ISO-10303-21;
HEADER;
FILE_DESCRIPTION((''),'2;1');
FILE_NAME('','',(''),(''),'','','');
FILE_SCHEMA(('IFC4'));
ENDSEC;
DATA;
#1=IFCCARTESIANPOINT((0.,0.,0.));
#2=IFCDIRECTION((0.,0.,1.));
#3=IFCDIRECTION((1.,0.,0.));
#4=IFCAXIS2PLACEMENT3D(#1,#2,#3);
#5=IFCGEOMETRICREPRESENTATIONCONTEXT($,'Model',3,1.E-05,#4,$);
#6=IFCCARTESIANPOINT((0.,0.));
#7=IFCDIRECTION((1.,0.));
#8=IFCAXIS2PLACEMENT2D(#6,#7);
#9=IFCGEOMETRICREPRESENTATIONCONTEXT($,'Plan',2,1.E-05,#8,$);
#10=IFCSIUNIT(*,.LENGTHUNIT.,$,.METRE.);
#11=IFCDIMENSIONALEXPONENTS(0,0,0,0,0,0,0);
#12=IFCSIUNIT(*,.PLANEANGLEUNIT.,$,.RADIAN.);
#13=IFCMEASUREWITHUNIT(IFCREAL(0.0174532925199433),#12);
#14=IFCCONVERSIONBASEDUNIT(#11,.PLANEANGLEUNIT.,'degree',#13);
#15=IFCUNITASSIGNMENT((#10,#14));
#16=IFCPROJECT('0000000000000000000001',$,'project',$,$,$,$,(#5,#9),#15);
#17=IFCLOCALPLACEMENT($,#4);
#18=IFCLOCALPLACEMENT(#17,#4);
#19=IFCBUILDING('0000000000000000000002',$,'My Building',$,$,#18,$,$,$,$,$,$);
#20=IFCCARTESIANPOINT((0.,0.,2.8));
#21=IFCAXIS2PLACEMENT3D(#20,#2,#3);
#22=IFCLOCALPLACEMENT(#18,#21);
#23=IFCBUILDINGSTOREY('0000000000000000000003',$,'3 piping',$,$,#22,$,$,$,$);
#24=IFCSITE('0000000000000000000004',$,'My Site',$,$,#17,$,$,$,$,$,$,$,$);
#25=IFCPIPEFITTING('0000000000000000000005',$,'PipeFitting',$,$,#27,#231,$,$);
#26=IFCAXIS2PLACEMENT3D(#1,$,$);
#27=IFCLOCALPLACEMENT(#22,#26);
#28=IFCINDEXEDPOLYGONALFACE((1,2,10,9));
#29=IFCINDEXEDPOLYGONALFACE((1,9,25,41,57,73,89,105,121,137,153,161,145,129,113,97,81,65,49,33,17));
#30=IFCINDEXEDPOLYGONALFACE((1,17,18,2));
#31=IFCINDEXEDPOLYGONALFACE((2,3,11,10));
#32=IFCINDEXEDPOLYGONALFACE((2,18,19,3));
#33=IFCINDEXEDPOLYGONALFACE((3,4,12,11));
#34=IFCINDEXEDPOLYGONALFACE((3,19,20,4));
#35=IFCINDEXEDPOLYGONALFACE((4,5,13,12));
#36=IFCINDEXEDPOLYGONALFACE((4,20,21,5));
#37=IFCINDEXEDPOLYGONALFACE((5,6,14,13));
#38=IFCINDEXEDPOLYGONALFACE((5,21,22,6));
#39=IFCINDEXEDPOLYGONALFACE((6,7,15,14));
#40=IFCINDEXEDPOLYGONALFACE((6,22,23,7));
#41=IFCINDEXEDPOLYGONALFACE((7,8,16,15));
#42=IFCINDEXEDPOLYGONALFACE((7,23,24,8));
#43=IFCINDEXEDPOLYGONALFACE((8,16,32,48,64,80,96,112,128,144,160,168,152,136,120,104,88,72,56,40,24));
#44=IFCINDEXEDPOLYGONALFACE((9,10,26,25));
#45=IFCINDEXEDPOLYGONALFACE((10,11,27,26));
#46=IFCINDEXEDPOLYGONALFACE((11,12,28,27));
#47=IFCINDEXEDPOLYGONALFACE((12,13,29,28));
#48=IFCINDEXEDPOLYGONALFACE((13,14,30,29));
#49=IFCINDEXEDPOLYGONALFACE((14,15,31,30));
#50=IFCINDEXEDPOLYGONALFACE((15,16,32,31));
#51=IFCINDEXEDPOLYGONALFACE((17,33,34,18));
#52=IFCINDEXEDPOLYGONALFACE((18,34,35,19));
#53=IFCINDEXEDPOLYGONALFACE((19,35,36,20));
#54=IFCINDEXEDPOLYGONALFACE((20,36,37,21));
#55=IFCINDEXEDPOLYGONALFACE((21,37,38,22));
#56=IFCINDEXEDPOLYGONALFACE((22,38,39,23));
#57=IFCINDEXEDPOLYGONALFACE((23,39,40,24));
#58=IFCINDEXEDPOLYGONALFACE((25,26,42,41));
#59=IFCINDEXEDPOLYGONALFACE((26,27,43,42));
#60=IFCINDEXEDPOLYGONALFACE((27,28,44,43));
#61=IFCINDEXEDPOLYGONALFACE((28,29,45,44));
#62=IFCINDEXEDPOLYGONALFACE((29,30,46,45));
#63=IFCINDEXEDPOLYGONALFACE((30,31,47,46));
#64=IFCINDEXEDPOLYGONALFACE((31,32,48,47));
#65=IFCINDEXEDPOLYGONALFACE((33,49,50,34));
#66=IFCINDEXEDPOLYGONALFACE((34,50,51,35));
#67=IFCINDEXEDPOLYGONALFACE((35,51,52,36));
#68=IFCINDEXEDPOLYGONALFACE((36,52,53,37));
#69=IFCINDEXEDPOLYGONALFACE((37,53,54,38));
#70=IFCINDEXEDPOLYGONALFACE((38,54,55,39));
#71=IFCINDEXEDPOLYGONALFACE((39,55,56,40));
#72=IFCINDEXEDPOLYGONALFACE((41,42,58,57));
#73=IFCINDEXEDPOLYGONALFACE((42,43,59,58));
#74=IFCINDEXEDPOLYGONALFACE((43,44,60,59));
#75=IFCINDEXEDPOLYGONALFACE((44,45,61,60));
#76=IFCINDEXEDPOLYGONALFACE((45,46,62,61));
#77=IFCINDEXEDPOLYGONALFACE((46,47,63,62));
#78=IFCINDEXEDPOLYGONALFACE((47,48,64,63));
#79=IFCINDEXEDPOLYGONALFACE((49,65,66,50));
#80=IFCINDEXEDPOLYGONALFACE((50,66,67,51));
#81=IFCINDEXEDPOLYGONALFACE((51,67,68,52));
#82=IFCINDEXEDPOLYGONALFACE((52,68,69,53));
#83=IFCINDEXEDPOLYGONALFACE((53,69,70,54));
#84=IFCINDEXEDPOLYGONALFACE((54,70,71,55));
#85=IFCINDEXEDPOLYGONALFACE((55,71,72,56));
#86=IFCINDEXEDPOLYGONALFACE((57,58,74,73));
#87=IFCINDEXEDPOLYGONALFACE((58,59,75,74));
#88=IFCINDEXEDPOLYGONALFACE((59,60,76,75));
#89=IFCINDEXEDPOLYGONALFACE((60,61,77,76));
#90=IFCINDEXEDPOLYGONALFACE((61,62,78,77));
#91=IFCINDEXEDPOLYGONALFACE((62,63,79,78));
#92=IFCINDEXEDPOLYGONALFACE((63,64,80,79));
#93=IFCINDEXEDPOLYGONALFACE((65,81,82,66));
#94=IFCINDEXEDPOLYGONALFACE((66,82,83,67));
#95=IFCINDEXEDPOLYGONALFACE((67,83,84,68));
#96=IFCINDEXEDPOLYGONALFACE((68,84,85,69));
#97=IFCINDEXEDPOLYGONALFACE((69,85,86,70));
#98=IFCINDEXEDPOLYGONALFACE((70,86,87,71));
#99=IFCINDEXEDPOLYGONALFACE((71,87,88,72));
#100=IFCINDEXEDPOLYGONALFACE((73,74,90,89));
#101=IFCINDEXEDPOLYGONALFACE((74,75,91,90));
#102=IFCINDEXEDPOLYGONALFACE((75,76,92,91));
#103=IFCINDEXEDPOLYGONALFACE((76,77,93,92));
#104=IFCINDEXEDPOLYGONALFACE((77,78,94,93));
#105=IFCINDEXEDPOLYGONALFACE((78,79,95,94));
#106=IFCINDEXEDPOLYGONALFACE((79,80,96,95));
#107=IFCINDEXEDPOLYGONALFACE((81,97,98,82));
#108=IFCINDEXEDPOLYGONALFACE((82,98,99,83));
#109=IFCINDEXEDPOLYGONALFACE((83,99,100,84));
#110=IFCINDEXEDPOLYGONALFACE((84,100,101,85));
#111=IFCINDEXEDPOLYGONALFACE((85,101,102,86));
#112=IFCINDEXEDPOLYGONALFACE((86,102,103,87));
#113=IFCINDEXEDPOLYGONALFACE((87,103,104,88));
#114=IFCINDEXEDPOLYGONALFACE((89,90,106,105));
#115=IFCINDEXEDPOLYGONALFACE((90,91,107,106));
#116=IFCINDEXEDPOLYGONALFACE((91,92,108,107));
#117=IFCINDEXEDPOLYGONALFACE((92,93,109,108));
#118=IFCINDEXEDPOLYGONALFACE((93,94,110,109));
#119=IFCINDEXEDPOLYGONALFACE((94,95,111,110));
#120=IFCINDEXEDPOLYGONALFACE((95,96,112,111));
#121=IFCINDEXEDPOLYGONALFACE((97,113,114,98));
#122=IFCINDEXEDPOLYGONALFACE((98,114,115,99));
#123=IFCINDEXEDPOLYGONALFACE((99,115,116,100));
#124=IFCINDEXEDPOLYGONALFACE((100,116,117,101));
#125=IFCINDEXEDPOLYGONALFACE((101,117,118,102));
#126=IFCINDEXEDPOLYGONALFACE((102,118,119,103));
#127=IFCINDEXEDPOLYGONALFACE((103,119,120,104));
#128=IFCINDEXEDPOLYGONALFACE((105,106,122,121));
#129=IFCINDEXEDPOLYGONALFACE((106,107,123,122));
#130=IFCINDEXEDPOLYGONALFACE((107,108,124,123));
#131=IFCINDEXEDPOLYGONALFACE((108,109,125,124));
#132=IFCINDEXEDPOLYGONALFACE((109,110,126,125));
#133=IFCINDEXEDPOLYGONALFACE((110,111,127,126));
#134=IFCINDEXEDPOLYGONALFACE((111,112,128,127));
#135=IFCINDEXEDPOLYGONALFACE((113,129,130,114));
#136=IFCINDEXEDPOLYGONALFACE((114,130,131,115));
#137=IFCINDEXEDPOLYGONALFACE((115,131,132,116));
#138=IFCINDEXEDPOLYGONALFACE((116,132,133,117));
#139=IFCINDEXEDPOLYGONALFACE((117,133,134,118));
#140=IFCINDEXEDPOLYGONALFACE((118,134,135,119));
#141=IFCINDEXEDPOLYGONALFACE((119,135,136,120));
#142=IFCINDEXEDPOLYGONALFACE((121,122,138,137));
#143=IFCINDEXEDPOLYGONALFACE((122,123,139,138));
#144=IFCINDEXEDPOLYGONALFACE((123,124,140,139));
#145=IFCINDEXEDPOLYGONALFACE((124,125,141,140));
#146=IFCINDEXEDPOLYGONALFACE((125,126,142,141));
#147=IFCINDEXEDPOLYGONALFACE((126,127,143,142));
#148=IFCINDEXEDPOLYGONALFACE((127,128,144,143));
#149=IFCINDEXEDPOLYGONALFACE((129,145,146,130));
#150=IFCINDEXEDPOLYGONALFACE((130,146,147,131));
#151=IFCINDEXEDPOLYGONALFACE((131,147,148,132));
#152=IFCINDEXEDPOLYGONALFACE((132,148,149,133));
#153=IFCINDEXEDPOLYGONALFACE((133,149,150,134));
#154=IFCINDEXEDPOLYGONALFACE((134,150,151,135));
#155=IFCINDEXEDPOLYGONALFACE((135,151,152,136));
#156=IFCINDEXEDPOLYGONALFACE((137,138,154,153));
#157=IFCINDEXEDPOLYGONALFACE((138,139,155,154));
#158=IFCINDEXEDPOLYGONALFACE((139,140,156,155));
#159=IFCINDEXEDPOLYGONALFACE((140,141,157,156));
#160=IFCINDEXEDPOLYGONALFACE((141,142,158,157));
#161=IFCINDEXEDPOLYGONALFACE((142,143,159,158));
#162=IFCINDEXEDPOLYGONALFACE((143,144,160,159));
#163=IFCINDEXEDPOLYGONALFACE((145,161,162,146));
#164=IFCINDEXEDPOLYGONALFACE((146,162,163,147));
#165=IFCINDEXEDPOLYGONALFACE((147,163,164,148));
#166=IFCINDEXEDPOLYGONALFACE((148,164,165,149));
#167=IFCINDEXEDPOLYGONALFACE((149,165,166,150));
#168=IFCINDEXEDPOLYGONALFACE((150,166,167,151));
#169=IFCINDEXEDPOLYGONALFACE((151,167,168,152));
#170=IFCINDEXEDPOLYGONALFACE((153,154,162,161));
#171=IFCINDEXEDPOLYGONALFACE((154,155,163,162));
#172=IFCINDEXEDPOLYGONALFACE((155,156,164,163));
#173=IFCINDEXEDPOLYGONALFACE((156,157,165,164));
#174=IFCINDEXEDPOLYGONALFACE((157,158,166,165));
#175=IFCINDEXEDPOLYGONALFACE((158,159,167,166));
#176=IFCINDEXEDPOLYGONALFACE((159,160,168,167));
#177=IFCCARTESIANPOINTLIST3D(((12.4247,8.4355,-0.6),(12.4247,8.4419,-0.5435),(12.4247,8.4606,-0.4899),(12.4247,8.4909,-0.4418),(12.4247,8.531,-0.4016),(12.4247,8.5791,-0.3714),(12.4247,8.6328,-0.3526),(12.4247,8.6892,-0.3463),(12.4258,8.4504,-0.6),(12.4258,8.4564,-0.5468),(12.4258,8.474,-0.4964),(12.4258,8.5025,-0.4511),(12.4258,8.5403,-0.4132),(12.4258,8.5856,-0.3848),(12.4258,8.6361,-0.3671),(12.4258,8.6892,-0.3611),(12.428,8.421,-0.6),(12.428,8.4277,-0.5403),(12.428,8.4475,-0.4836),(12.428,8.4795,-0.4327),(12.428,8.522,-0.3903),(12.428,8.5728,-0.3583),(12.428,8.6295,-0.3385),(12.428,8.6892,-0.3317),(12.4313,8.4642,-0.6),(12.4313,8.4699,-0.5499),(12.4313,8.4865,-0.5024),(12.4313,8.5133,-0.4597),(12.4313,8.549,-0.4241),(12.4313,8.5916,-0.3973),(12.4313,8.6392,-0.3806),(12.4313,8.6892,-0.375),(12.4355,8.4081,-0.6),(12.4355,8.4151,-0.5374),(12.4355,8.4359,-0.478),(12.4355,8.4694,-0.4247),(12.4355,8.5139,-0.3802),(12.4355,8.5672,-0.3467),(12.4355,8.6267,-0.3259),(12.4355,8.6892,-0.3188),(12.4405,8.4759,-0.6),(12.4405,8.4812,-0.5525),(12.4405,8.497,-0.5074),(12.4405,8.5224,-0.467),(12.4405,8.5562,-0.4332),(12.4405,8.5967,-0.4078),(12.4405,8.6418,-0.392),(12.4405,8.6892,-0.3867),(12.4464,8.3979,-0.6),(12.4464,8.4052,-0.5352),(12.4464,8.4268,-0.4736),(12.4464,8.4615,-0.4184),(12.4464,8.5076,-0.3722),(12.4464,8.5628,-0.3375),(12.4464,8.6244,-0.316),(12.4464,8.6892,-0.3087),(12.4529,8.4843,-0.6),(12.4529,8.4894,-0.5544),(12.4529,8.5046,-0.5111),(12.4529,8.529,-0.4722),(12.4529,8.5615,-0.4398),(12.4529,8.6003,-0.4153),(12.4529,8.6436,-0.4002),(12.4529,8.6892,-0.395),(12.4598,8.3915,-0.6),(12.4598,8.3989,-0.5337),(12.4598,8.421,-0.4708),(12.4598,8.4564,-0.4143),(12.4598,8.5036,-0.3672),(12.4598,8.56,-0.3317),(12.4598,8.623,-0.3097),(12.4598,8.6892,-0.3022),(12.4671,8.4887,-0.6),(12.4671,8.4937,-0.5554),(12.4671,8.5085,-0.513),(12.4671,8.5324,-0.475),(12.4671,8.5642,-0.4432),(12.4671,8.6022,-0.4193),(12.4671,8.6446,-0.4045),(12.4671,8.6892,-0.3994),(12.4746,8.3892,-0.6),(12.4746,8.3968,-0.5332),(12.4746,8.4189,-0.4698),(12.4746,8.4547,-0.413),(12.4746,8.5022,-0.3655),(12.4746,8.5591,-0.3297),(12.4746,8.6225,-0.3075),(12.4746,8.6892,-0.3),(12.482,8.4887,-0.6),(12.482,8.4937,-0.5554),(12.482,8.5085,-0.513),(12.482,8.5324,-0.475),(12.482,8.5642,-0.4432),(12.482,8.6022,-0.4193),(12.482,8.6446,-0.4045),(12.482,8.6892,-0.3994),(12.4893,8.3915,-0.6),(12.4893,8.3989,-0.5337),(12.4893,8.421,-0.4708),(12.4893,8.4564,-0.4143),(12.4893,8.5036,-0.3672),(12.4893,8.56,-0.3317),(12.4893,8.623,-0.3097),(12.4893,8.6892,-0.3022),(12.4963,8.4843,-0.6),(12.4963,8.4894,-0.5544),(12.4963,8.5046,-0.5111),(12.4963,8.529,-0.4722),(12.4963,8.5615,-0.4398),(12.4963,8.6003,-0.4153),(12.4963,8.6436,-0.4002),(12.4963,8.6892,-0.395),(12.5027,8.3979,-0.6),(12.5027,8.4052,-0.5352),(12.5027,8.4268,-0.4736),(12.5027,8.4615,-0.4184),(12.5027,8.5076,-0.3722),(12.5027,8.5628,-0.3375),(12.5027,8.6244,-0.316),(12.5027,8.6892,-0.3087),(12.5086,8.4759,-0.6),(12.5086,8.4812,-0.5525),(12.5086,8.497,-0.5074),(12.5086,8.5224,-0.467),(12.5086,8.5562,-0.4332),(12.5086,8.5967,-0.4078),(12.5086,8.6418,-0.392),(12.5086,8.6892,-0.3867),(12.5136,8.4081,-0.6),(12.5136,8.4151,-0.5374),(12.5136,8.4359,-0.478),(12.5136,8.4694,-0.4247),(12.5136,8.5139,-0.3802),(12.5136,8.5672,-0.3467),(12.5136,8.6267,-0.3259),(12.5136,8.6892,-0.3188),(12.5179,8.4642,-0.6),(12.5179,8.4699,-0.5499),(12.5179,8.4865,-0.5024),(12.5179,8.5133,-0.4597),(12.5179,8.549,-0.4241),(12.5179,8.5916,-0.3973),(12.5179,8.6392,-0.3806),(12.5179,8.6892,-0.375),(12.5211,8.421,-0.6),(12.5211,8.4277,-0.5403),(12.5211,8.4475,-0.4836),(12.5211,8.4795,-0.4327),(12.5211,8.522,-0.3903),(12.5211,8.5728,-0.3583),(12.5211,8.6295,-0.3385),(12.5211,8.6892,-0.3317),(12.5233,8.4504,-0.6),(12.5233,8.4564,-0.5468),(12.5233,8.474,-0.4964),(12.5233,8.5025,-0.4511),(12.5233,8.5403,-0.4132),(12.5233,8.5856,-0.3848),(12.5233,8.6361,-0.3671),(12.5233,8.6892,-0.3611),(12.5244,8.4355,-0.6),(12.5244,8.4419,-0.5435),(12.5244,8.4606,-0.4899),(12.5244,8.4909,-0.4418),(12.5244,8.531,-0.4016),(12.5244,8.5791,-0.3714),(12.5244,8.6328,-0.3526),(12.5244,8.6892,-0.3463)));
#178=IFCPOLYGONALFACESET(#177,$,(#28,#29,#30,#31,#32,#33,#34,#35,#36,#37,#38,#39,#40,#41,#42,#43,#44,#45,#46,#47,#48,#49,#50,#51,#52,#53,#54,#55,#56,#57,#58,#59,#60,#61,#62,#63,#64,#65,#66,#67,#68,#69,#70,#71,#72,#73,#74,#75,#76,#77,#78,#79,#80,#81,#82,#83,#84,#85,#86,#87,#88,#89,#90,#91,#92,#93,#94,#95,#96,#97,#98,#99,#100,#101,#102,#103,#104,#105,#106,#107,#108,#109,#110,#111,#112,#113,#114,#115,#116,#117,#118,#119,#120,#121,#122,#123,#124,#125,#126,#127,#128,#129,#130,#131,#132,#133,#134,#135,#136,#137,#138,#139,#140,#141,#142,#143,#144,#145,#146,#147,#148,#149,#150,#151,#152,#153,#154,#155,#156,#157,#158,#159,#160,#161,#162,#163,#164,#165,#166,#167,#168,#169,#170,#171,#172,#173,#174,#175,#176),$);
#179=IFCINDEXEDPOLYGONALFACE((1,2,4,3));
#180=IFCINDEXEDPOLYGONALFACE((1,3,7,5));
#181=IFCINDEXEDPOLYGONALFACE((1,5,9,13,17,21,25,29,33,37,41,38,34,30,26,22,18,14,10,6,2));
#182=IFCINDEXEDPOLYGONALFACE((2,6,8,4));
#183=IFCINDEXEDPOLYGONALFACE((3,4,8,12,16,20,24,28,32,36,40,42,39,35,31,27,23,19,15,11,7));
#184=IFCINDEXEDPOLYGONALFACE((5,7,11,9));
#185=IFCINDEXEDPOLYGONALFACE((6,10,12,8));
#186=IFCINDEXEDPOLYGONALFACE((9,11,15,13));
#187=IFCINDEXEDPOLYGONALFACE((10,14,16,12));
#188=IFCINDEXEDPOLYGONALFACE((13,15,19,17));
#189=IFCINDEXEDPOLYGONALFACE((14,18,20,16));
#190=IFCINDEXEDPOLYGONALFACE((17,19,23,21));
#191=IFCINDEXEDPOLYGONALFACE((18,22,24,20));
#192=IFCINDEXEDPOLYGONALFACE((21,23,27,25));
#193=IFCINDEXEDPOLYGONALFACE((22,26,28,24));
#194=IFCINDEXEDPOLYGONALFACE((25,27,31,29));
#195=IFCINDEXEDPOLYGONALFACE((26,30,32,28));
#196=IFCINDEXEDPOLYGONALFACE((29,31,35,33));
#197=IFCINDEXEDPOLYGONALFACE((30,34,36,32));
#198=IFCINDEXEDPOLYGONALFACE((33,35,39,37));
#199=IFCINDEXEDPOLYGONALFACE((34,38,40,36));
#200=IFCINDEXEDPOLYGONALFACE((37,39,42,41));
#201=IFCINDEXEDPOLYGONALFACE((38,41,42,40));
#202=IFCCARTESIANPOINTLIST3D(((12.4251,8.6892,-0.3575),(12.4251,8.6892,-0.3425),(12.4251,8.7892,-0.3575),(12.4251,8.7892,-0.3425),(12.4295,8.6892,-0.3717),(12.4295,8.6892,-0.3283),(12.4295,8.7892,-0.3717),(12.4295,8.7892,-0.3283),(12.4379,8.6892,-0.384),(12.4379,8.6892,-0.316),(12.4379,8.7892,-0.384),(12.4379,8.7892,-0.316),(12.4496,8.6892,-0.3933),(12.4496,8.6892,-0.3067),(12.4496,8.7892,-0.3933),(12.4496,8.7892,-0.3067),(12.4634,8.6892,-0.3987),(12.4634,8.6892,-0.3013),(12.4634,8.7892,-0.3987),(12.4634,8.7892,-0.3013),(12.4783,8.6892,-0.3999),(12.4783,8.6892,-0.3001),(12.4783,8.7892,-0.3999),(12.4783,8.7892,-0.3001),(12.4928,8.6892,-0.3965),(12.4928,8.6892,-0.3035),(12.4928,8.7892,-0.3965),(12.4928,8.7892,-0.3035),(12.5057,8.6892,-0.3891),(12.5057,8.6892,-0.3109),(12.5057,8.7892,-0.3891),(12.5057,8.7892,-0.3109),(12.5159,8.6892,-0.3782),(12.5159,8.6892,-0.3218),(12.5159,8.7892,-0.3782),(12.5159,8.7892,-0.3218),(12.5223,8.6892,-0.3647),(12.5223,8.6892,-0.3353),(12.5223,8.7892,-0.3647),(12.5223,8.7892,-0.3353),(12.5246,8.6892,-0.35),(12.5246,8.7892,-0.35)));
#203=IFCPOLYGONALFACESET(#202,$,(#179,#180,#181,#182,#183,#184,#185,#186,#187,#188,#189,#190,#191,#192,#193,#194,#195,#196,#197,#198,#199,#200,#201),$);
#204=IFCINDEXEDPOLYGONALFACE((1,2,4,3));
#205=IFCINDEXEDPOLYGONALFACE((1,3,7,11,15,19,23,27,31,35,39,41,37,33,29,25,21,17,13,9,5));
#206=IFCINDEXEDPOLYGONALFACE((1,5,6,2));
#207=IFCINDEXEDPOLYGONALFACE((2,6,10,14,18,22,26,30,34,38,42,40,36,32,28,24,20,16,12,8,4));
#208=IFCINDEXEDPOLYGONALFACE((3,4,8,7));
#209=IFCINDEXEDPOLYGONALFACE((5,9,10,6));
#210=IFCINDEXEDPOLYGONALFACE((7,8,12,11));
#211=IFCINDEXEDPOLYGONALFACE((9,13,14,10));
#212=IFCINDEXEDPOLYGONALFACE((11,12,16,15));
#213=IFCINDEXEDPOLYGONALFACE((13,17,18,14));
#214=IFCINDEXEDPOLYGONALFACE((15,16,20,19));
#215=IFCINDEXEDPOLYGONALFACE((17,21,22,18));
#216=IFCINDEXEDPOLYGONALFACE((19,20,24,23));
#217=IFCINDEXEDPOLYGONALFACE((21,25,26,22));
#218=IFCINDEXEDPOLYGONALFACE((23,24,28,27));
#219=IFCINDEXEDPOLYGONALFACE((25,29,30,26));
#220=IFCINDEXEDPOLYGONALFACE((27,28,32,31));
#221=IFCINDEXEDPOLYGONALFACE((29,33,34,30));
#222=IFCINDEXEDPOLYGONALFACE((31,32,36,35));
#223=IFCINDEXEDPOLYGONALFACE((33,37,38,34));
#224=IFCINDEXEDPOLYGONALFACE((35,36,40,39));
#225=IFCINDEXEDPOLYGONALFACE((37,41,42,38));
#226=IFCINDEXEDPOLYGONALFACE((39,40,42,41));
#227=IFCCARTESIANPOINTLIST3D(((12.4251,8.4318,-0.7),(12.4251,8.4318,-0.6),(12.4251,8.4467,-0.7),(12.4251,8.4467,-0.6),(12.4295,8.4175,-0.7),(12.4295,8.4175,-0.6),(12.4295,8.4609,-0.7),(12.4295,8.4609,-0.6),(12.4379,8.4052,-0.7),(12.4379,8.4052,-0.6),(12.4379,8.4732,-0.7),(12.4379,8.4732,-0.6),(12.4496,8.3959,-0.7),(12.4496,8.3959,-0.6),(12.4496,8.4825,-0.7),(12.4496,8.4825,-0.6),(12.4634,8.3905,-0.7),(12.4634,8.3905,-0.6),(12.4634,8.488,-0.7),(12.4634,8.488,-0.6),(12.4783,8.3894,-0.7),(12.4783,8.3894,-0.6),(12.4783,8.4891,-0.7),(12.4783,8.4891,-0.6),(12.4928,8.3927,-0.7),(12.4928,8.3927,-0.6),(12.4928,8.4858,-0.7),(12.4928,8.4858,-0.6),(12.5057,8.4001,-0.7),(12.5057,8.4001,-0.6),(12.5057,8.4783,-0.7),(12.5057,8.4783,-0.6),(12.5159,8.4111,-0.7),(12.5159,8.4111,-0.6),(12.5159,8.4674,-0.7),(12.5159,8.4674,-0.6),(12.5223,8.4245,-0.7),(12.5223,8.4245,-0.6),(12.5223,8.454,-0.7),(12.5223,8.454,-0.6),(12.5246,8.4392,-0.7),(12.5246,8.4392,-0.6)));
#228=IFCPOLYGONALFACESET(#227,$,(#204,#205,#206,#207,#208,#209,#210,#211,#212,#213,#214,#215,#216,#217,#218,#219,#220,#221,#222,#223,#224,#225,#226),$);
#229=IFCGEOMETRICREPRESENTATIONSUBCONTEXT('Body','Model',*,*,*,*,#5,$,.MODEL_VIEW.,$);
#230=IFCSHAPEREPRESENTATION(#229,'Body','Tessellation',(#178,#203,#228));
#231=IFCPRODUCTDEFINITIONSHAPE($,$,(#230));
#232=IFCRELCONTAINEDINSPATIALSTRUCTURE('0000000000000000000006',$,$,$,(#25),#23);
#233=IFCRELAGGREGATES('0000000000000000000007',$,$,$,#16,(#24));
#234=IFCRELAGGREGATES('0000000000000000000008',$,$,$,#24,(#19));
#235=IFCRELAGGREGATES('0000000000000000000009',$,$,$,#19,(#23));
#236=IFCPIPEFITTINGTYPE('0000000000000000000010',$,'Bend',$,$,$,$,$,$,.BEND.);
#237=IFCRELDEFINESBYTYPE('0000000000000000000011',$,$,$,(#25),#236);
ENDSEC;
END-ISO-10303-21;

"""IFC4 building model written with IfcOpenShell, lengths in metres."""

from ifc_helpers import new_model, entity, si_unit, converted_unit, frame, origin_with_axes, origin_2d_with_axis, place, context, subcontext, project, spatial, circle, extrude, source, transform, mapped, type_object, type_shapes, element, save


model = new_model("IFC4")

# Units and contexts
model_context = context("Model", 3, precision=1e-05, world=origin_with_axes())
plan_context = context("Plan", 2, precision=1e-05, world=origin_2d_with_axis())
body_context = subcontext(model_context, "Body", "Model", "MODEL_VIEW")
ifc_project = project(units=[si_unit("LENGTHUNIT", "METRE"), converted_unit("PLANEANGLEUNIT", "degree", entity("IfcReal", 0.0174532925199433), si_unit("PLANEANGLEUNIT", "RADIAN"), dimensions=[0, 0, 0, 0, 0, 0, 0])], contexts=[model_context, plan_context])

# Site, building, storey
site_placement = place(None, origin_with_axes())
site = spatial("IfcSite", under=ifc_project, at=site_placement, Name="My Site")
building_placement = place(site_placement, origin_with_axes())
building = spatial("IfcBuilding", under=site, at=building_placement, Name="My Building")
storey_placement = place(building_placement, frame((0.0, 0.0, 2.8), z_axis=(0.0, 0.0, 1.0), x_axis=(1.0, 0.0, 0.0)))
storey = spatial("IfcBuildingStorey", under=building, at=storey_placement, Name="3 piping")

# Pipe fitting
pipe_fitting_type_1 = type_object("IfcPipeFittingType", Name="Bend", PredefinedType="BEND")
shared_shape = source(origin_with_axes(), body_context, "Body", "SolidModel", [
    entity("IfcSweptDiskSolid", entity("IfcIndexedPolyCurve", entity("IfcCartesianPointList3D", [[0.0, 0.0, 0.1], [0.0, -0.0732, 0.2768], [0.0, -0.25, 0.35]]), [entity("IfcArcIndex", [1, 2, 3])]), 0.05),
    extrude(circle(Radius=0.05), origin_with_axes(), (0.0, 0.0, 1.0), 0.1),
    extrude(circle(Radius=0.05), frame((0.0, -0.25, 0.35), z_axis=(0.0, -1.0, 0.0), x_axis=(1.0, 0.0, 0.0)), (0.0, 0.0, 1.0), 0.1),
])
type_shapes(pipe_fitting_type_1, [shared_shape])
for number, where, z_axis, x_axis, name in (
    (1, (12.4746, 8.7892, -0.35), (0.0, -1.0, 0.0), (1.0, 0.0, 0.0), "PipeFitting"),
):
    element("IfcPipeFitting", number, at=place(storey_placement, frame(where, z_axis=z_axis, x_axis=x_axis)), inside=storey, type_object=pipe_fitting_type_1, Name=name, context=body_context, shape_type="MappedRepresentation", body=[
        mapped(shared_shape, transform((0.0, 0.0, 0.0), x_axis=(1.0, 0.0, 0.0), y_axis=(0.0, 1.0, 0.0), z_axis=(0.0, 0.0, 1.0), scale=1.0)),
    ])

save(model, "model.ifc")
